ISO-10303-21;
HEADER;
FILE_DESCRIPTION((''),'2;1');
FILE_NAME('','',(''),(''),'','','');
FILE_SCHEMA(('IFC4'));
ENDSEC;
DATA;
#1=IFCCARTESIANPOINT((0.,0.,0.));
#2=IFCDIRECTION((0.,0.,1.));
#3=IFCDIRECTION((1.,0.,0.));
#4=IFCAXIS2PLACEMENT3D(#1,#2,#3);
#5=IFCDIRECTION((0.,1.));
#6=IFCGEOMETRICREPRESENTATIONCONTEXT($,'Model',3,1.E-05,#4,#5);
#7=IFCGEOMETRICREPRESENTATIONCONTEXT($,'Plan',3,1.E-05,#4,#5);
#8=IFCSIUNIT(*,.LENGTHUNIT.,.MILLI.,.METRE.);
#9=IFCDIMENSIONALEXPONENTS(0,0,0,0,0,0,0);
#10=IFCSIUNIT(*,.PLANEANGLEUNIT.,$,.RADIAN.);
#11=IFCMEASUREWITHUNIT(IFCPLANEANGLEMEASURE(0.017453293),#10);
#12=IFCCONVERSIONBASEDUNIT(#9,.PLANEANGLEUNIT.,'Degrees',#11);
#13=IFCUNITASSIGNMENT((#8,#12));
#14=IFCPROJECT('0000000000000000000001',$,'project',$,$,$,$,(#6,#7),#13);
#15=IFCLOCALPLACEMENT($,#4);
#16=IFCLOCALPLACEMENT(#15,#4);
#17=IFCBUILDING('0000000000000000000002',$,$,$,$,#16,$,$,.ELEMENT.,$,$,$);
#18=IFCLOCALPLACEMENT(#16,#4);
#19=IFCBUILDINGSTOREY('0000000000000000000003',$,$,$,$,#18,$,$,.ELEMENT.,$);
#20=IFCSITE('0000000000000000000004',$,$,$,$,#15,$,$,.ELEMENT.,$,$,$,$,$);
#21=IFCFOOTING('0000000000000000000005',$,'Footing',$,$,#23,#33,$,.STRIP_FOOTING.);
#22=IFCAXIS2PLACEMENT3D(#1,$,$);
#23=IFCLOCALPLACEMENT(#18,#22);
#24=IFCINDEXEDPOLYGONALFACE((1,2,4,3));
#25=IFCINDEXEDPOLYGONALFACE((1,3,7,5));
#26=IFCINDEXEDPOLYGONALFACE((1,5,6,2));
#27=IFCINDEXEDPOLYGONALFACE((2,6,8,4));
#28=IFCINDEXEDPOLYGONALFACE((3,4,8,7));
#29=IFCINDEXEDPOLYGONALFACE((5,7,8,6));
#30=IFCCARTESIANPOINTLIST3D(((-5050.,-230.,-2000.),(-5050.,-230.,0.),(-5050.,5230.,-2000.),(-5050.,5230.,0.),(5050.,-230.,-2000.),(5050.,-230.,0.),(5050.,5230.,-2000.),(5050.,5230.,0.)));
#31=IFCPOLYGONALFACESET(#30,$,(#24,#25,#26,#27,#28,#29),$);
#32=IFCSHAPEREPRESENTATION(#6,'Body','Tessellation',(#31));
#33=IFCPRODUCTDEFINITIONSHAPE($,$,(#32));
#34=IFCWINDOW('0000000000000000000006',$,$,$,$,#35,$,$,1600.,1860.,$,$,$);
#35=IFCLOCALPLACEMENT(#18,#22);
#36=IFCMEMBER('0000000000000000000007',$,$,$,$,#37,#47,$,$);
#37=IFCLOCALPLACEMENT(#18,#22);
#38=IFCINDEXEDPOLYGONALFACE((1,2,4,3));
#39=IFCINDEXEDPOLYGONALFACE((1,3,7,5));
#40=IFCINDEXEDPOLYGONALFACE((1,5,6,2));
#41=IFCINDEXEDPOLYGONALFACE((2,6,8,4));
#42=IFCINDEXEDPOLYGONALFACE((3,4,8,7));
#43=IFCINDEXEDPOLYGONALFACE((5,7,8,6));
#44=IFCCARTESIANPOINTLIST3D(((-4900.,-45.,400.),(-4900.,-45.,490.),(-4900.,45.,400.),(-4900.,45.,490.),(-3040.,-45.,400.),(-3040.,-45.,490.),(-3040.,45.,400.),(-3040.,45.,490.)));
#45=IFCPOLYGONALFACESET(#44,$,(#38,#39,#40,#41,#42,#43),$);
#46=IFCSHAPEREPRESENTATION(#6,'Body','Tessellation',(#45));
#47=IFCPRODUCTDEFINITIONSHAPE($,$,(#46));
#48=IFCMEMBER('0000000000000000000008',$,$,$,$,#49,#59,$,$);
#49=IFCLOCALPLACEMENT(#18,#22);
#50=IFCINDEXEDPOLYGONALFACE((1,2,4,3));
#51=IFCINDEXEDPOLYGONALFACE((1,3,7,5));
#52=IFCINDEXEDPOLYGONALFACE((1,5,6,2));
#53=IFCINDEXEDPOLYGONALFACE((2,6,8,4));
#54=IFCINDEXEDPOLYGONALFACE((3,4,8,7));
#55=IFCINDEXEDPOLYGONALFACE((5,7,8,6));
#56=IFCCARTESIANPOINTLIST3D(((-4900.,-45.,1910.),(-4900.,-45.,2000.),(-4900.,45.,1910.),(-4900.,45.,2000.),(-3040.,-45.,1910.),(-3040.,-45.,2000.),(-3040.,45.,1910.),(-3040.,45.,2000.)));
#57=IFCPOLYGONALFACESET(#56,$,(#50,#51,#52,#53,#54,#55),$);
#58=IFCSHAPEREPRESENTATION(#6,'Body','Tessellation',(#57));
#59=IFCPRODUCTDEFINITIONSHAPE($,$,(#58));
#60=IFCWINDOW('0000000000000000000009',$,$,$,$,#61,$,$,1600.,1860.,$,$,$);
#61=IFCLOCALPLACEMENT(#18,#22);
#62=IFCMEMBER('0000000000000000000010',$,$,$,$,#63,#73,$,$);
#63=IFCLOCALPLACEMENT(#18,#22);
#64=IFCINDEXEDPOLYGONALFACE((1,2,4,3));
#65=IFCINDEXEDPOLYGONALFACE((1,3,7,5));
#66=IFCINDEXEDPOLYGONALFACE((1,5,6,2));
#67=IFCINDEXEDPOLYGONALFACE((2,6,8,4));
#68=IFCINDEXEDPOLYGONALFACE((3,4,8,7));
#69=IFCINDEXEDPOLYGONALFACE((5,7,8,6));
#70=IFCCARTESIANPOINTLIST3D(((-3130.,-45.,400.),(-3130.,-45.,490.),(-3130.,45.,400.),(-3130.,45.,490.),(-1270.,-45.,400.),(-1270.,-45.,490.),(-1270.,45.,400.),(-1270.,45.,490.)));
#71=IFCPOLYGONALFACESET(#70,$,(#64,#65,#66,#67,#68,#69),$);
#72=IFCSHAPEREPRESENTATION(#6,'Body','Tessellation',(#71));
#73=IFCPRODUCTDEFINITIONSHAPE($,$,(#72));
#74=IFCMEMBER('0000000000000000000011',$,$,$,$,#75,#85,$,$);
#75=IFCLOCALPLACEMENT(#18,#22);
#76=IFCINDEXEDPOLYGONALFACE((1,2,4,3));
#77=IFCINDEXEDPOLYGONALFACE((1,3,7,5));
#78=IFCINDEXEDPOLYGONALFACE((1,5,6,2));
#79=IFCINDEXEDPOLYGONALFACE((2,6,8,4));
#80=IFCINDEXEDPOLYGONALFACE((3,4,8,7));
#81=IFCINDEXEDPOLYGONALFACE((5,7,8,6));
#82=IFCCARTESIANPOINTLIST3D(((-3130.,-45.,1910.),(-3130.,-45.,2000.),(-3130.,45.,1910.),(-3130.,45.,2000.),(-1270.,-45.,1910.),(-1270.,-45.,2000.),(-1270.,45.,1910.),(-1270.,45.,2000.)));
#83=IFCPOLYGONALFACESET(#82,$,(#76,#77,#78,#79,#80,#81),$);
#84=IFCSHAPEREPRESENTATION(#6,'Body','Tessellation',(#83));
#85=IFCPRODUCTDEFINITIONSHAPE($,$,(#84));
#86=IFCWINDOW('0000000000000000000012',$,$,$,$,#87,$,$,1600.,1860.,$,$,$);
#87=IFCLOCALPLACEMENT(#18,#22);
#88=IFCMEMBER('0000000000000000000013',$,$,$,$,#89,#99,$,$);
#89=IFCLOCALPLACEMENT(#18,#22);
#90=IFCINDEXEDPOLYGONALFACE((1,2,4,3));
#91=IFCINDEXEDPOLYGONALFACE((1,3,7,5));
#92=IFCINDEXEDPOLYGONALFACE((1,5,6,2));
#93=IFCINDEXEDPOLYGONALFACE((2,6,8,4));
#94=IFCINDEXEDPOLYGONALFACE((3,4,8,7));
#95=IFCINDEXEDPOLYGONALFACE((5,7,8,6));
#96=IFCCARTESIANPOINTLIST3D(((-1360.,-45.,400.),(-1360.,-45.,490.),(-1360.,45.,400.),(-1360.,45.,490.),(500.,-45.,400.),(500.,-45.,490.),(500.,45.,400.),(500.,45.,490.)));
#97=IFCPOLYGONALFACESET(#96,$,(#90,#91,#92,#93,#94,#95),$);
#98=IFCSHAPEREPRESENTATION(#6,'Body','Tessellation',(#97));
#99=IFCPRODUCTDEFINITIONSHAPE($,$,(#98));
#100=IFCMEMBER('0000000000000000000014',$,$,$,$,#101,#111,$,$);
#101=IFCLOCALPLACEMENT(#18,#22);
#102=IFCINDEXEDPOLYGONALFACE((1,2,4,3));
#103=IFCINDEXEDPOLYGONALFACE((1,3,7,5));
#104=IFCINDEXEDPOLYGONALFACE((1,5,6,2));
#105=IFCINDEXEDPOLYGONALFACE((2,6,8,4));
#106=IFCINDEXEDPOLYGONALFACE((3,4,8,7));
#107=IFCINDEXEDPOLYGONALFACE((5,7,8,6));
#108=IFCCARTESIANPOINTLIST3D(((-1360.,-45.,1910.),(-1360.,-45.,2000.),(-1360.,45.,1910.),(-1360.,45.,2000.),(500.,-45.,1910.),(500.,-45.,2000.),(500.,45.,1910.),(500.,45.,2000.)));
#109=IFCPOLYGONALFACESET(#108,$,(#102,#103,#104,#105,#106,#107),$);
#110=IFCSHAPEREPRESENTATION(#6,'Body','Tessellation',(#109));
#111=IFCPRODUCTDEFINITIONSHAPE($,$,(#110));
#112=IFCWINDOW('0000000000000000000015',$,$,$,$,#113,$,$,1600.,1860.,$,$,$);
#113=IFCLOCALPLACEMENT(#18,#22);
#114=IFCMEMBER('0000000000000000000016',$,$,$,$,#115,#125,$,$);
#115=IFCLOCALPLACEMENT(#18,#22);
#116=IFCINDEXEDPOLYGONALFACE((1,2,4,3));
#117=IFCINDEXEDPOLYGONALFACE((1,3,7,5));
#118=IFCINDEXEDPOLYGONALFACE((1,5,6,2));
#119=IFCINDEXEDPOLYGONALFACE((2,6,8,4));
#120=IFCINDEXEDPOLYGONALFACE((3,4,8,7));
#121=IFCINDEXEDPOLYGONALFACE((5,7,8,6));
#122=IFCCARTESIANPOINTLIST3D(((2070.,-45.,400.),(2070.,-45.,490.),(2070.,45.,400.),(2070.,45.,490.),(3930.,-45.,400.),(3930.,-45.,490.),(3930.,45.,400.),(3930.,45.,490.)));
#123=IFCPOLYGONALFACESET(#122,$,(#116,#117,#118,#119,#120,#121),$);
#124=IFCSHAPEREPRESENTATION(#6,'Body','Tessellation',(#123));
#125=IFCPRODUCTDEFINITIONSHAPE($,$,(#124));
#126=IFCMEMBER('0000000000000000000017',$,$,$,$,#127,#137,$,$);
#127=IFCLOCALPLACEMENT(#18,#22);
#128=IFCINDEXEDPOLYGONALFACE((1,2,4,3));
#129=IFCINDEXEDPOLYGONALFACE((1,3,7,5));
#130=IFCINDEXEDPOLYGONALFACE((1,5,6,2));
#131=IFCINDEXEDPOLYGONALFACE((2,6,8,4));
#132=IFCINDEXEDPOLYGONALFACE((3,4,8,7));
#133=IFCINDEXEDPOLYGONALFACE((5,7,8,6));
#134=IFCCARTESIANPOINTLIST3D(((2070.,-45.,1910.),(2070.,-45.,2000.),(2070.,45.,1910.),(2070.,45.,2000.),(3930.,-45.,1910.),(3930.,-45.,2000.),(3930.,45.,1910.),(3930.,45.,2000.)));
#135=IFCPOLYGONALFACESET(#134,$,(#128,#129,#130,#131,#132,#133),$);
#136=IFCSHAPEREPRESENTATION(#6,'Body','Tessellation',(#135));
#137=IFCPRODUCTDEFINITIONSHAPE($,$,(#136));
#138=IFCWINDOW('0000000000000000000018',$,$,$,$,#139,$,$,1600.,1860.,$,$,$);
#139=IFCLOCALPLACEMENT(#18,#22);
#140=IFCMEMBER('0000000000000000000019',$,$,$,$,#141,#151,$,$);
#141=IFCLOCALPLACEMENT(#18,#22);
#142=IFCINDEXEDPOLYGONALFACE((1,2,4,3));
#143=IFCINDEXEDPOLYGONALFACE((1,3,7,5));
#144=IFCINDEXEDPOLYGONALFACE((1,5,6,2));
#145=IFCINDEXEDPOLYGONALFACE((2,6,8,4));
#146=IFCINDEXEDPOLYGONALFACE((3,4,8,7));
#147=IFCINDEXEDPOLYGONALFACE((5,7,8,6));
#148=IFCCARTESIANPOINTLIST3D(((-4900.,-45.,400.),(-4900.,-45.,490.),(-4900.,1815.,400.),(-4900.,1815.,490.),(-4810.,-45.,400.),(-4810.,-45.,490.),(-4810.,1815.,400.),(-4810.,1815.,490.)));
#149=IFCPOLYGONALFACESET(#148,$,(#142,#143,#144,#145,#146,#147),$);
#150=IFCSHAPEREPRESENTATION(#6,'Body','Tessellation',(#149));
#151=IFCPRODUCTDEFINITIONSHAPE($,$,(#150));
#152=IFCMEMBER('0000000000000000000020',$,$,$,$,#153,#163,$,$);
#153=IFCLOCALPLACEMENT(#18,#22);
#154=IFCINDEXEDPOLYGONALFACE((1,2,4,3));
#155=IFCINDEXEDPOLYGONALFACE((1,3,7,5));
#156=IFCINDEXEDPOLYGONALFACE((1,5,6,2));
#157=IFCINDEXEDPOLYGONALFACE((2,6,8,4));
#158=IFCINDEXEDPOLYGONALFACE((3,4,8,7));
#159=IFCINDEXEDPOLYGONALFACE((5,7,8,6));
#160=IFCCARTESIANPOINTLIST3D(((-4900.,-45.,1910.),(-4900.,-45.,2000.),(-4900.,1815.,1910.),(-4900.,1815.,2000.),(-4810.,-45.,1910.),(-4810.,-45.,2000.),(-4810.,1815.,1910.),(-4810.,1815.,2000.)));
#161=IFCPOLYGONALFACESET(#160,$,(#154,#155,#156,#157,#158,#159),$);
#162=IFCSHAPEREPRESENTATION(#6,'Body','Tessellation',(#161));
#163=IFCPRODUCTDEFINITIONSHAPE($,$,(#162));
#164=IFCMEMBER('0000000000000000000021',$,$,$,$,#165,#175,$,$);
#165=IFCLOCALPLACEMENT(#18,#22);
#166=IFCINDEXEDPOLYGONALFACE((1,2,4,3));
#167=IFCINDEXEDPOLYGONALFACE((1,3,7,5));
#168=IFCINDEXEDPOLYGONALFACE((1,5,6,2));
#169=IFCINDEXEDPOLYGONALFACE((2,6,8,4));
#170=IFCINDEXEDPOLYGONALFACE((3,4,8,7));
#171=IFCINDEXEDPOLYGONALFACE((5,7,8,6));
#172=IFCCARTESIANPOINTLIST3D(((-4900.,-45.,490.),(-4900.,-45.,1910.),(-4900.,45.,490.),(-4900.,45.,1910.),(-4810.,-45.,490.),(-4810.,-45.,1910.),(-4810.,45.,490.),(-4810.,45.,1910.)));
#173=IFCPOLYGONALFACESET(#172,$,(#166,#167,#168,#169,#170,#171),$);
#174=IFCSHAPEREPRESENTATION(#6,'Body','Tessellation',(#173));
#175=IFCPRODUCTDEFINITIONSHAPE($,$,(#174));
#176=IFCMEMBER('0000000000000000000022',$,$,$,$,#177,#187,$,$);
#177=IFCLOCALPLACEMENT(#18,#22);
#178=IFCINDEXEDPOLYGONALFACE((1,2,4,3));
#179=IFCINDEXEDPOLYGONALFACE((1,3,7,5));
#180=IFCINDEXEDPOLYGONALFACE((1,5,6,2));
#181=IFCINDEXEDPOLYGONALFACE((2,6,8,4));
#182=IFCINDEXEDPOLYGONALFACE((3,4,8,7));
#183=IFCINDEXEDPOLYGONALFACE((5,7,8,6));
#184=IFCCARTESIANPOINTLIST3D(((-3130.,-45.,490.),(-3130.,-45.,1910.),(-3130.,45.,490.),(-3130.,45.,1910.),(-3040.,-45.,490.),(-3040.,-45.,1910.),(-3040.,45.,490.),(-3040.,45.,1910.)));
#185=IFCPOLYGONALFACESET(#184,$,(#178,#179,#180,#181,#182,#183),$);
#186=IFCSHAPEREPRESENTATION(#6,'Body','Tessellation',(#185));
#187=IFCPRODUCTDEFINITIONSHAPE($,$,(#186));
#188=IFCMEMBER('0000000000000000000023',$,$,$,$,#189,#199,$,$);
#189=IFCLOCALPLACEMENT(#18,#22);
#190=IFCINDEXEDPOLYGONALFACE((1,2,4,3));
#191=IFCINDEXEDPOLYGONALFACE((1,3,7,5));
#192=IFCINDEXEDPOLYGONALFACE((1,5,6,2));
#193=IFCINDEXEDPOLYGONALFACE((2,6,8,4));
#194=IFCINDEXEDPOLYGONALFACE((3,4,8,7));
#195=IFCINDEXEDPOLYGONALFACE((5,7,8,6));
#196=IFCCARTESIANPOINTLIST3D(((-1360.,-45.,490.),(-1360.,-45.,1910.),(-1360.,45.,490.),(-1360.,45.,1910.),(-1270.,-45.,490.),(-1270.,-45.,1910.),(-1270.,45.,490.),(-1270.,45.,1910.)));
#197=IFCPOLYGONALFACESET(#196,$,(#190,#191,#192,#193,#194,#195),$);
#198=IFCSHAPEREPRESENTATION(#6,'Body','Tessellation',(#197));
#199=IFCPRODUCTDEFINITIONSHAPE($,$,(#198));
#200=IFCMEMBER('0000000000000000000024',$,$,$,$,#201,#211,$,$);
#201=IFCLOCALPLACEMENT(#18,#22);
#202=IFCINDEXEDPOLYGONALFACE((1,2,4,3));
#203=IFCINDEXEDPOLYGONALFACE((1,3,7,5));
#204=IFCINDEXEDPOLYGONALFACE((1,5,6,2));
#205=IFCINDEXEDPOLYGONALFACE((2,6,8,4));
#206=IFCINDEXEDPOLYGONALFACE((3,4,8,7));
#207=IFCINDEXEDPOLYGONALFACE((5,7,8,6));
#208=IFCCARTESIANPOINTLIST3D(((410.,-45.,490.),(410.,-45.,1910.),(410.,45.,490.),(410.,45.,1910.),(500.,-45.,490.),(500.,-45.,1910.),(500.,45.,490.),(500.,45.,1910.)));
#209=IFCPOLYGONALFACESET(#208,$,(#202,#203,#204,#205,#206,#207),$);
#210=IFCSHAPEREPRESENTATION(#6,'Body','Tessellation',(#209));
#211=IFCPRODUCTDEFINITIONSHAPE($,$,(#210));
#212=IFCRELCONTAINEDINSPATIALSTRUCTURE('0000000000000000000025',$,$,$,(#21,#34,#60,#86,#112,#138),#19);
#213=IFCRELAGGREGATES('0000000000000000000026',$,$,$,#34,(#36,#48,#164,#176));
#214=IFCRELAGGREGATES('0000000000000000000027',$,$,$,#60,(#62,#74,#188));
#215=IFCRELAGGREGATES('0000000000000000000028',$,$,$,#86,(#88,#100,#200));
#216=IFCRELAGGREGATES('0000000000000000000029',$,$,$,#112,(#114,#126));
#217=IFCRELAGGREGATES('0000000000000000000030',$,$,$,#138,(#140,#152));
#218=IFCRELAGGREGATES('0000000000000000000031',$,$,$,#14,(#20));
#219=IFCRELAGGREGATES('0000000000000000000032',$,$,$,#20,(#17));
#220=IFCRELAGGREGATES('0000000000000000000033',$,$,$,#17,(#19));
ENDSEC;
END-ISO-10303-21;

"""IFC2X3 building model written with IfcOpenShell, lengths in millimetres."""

from ifc_helpers import new_model, entity, si_unit, converted_unit, direction, frame, origin_with_axes, place, context, project, spatial, polyline, outline, extrude, source, transform, mapped, element, aggregate, save


model = new_model("IFC2X3")

# Units and contexts
model_context = context("Model", 3, precision=1e-05, world=origin_with_axes(), true_north=direction((0.0, 1.0)))
plan_context = context("Plan", 3, precision=1e-05, world=origin_with_axes(), true_north=direction((0.0, 1.0)))
ifc_project = project(units=[si_unit("LENGTHUNIT", "METRE", prefix="MILLI"), converted_unit("PLANEANGLEUNIT", "Degrees", entity("IfcPlaneAngleMeasure", 0.017453293), si_unit("PLANEANGLEUNIT", "RADIAN"), dimensions=[0, 0, 0, 0, 0, 0, 0])], contexts=[model_context, plan_context])

# Site, building, storey
site_placement = place(None, origin_with_axes())
site = spatial("IfcSite", under=ifc_project, at=site_placement, CompositionType="ELEMENT")
building_placement = place(site_placement, origin_with_axes())
building = spatial("IfcBuilding", under=site, at=building_placement, CompositionType="ELEMENT")
storey_placement = place(building_placement, origin_with_axes())
storey = spatial("IfcBuildingStorey", under=building, at=storey_placement, CompositionType="ELEMENT")

# Footing
footing_placement = place(storey_placement, frame((0.0, 2500.0, -2000.0), z_axis=(0.0, 0.0, 1.0), x_axis=(1.0, 0.0, 0.0)))
element("IfcFooting", 1, at=footing_placement, inside=storey, Name="Footing", PredefinedType="STRIP_FOOTING", context=model_context, shape_type="SweptSolid", body=[
    extrude(outline(polyline([(-5050.0, -2730.0), (5050.0, -2730.0), (5050.0, 2730.0), (-5050.0, 2730.0), (-5050.0, -2730.0)])), origin_with_axes(), (0.0, 0.0, 1.0), 2000.0),
])

# Windows, members
window_1_placement = place(storey_placement, frame((-4900.0, -45.0, 400.0), z_axis=(0.0, 0.0, 1.0), x_axis=(1.0, 0.0, 0.0)))
window_1 = element("IfcWindow", 2, at=window_1_placement, inside=storey, OverallHeight=1600.0, OverallWidth=1860.0)
shared_shape_1 = source(origin_with_axes(), model_context, "Body", "SweptSolid", [
    extrude(outline(polyline([(-930.0, -45.0), (930.0, -45.0), (930.0, 45.0), (-930.0, 45.0), (-930.0, -45.0)])), origin_with_axes(), (0.0, 0.0, 1.0), 90.0),
])
member_1_placement = place(window_1_placement, frame((930.0, 45.0, 0.0), z_axis=(0.0, 0.0, 1.0), x_axis=(1.0, 0.0, 0.0)))
member_1 = element("IfcMember", 3, at=member_1_placement, context=model_context, shape_type="MappedRepresentation", body=[
    mapped(shared_shape_1, transform((0.0, 0.0, 0.0))),
])
member_2_placement = place(window_1_placement, frame((930.0, 45.0, 1510.0), z_axis=(0.0, 0.0, 1.0), x_axis=(1.0, 0.0, 0.0)))
member_2 = element("IfcMember", 4, at=member_2_placement, context=model_context, shape_type="MappedRepresentation", body=[
    mapped(shared_shape_1, transform((0.0, 0.0, 0.0))),
])
window_2_placement = place(storey_placement, frame((-3130.0, -45.0, 400.0), z_axis=(0.0, 0.0, 1.0), x_axis=(1.0, 0.0, 0.0)))
window_2 = element("IfcWindow", 5, at=window_2_placement, inside=storey, OverallHeight=1600.0, OverallWidth=1860.0)
member_3_placement = place(window_2_placement, frame((930.0, 45.0, 0.0), z_axis=(0.0, 0.0, 1.0), x_axis=(1.0, 0.0, 0.0)))
member_3 = element("IfcMember", 6, at=member_3_placement, context=model_context, shape_type="MappedRepresentation", body=[
    mapped(shared_shape_1, transform((0.0, 0.0, 0.0))),
])
member_4_placement = place(window_2_placement, frame((930.0, 45.0, 1510.0), z_axis=(0.0, 0.0, 1.0), x_axis=(1.0, 0.0, 0.0)))
member_4 = element("IfcMember", 7, at=member_4_placement, context=model_context, shape_type="MappedRepresentation", body=[
    mapped(shared_shape_1, transform((0.0, 0.0, 0.0))),
])
window_3_placement = place(storey_placement, frame((-1360.0, -45.0, 400.0), z_axis=(0.0, 0.0, 1.0), x_axis=(1.0, 0.0, 0.0)))
window_3 = element("IfcWindow", 8, at=window_3_placement, inside=storey, OverallHeight=1600.0, OverallWidth=1860.0)
member_5_placement = place(window_3_placement, frame((930.0, 45.0, 0.0), z_axis=(0.0, 0.0, 1.0), x_axis=(1.0, 0.0, 0.0)))
member_5 = element("IfcMember", 9, at=member_5_placement, context=model_context, shape_type="MappedRepresentation", body=[
    mapped(shared_shape_1, transform((0.0, 0.0, 0.0))),
])
member_6_placement = place(window_3_placement, frame((930.0, 45.0, 1510.0), z_axis=(0.0, 0.0, 1.0), x_axis=(1.0, 0.0, 0.0)))
member_6 = element("IfcMember", 10, at=member_6_placement, context=model_context, shape_type="MappedRepresentation", body=[
    mapped(shared_shape_1, transform((0.0, 0.0, 0.0))),
])
window_4_placement = place(storey_placement, frame((2070.0, -45.0, 400.0), z_axis=(0.0, 0.0, 1.0), x_axis=(1.0, 0.0, 0.0)))
window_4 = element("IfcWindow", 11, at=window_4_placement, inside=storey, OverallHeight=1600.0, OverallWidth=1860.0)
member_7_placement = place(window_4_placement, frame((930.0, 45.0, 0.0), z_axis=(0.0, 0.0, 1.0), x_axis=(1.0, 0.0, 0.0)))
member_7 = element("IfcMember", 12, at=member_7_placement, context=model_context, shape_type="MappedRepresentation", body=[
    mapped(shared_shape_1, transform((0.0, 0.0, 0.0))),
])
member_8_placement = place(window_4_placement, frame((930.0, 45.0, 1510.0), z_axis=(0.0, 0.0, 1.0), x_axis=(1.0, 0.0, 0.0)))
member_8 = element("IfcMember", 13, at=member_8_placement, context=model_context, shape_type="MappedRepresentation", body=[
    mapped(shared_shape_1, transform((0.0, 0.0, 0.0))),
])
window_5_placement = place(storey_placement, frame((-4810.0, -45.0, 400.0), z_axis=(0.0, 0.0, 1.0), x_axis=(0.0, 1.0, 0.0)))
window_5 = element("IfcWindow", 14, at=window_5_placement, inside=storey, OverallHeight=1600.0, OverallWidth=1860.0)
member_9_placement = place(window_5_placement, frame((930.0, 45.0, 0.0), z_axis=(0.0, 0.0, 1.0), x_axis=(1.0, 0.0, 0.0)))
member_9 = element("IfcMember", 15, at=member_9_placement, context=model_context, shape_type="MappedRepresentation", body=[
    mapped(shared_shape_1, transform((0.0, 0.0, 0.0))),
])
member_10_placement = place(window_5_placement, frame((930.0, 45.0, 1510.0), z_axis=(0.0, 0.0, 1.0), x_axis=(1.0, 0.0, 0.0)))
member_10 = element("IfcMember", 16, at=member_10_placement, context=model_context, shape_type="MappedRepresentation", body=[
    mapped(shared_shape_1, transform((0.0, 0.0, 0.0))),
])

# Members
shared_shape_2 = source(origin_with_axes(), model_context, "Body", "SweptSolid", [
    extrude(outline(polyline([(-45.0, -45.0), (45.0, -45.0), (45.0, 45.0), (-45.0, 45.0), (-45.0, -45.0)])), origin_with_axes(), (0.0, 0.0, 1.0), 1420.0),
])
member_11_placement = place(window_1_placement, frame((45.0, 45.0, 90.0), z_axis=(0.0, 0.0, 1.0), x_axis=(1.0, 0.0, 0.0)))
member_11 = element("IfcMember", 17, at=member_11_placement, context=model_context, shape_type="MappedRepresentation", body=[
    mapped(shared_shape_2, transform((0.0, 0.0, 0.0))),
])
member_12_placement = place(window_1_placement, frame((1815.0, 45.0, 90.0), z_axis=(0.0, 0.0, 1.0), x_axis=(1.0, 0.0, 0.0)))
member_12 = element("IfcMember", 18, at=member_12_placement, context=model_context, shape_type="MappedRepresentation", body=[
    mapped(shared_shape_2, transform((0.0, 0.0, 0.0))),
])
member_13_placement = place(window_2_placement, frame((1815.0, 45.0, 90.0), z_axis=(0.0, 0.0, 1.0), x_axis=(1.0, 0.0, 0.0)))
member_13 = element("IfcMember", 19, at=member_13_placement, context=model_context, shape_type="MappedRepresentation", body=[
    mapped(shared_shape_2, transform((0.0, 0.0, 0.0))),
])
member_14_placement = place(window_3_placement, frame((1815.0, 45.0, 90.0), z_axis=(0.0, 0.0, 1.0), x_axis=(1.0, 0.0, 0.0)))
member_14 = element("IfcMember", 20, at=member_14_placement, context=model_context, shape_type="MappedRepresentation", body=[
    mapped(shared_shape_2, transform((0.0, 0.0, 0.0))),
])

aggregate(window_1, [member_1, member_2, member_11, member_12])
aggregate(window_2, [member_3, member_4, member_13])
aggregate(window_3, [member_5, member_6, member_14])
aggregate(window_4, [member_7, member_8])
aggregate(window_5, [member_9, member_10])

save(model, "model.ifc")
